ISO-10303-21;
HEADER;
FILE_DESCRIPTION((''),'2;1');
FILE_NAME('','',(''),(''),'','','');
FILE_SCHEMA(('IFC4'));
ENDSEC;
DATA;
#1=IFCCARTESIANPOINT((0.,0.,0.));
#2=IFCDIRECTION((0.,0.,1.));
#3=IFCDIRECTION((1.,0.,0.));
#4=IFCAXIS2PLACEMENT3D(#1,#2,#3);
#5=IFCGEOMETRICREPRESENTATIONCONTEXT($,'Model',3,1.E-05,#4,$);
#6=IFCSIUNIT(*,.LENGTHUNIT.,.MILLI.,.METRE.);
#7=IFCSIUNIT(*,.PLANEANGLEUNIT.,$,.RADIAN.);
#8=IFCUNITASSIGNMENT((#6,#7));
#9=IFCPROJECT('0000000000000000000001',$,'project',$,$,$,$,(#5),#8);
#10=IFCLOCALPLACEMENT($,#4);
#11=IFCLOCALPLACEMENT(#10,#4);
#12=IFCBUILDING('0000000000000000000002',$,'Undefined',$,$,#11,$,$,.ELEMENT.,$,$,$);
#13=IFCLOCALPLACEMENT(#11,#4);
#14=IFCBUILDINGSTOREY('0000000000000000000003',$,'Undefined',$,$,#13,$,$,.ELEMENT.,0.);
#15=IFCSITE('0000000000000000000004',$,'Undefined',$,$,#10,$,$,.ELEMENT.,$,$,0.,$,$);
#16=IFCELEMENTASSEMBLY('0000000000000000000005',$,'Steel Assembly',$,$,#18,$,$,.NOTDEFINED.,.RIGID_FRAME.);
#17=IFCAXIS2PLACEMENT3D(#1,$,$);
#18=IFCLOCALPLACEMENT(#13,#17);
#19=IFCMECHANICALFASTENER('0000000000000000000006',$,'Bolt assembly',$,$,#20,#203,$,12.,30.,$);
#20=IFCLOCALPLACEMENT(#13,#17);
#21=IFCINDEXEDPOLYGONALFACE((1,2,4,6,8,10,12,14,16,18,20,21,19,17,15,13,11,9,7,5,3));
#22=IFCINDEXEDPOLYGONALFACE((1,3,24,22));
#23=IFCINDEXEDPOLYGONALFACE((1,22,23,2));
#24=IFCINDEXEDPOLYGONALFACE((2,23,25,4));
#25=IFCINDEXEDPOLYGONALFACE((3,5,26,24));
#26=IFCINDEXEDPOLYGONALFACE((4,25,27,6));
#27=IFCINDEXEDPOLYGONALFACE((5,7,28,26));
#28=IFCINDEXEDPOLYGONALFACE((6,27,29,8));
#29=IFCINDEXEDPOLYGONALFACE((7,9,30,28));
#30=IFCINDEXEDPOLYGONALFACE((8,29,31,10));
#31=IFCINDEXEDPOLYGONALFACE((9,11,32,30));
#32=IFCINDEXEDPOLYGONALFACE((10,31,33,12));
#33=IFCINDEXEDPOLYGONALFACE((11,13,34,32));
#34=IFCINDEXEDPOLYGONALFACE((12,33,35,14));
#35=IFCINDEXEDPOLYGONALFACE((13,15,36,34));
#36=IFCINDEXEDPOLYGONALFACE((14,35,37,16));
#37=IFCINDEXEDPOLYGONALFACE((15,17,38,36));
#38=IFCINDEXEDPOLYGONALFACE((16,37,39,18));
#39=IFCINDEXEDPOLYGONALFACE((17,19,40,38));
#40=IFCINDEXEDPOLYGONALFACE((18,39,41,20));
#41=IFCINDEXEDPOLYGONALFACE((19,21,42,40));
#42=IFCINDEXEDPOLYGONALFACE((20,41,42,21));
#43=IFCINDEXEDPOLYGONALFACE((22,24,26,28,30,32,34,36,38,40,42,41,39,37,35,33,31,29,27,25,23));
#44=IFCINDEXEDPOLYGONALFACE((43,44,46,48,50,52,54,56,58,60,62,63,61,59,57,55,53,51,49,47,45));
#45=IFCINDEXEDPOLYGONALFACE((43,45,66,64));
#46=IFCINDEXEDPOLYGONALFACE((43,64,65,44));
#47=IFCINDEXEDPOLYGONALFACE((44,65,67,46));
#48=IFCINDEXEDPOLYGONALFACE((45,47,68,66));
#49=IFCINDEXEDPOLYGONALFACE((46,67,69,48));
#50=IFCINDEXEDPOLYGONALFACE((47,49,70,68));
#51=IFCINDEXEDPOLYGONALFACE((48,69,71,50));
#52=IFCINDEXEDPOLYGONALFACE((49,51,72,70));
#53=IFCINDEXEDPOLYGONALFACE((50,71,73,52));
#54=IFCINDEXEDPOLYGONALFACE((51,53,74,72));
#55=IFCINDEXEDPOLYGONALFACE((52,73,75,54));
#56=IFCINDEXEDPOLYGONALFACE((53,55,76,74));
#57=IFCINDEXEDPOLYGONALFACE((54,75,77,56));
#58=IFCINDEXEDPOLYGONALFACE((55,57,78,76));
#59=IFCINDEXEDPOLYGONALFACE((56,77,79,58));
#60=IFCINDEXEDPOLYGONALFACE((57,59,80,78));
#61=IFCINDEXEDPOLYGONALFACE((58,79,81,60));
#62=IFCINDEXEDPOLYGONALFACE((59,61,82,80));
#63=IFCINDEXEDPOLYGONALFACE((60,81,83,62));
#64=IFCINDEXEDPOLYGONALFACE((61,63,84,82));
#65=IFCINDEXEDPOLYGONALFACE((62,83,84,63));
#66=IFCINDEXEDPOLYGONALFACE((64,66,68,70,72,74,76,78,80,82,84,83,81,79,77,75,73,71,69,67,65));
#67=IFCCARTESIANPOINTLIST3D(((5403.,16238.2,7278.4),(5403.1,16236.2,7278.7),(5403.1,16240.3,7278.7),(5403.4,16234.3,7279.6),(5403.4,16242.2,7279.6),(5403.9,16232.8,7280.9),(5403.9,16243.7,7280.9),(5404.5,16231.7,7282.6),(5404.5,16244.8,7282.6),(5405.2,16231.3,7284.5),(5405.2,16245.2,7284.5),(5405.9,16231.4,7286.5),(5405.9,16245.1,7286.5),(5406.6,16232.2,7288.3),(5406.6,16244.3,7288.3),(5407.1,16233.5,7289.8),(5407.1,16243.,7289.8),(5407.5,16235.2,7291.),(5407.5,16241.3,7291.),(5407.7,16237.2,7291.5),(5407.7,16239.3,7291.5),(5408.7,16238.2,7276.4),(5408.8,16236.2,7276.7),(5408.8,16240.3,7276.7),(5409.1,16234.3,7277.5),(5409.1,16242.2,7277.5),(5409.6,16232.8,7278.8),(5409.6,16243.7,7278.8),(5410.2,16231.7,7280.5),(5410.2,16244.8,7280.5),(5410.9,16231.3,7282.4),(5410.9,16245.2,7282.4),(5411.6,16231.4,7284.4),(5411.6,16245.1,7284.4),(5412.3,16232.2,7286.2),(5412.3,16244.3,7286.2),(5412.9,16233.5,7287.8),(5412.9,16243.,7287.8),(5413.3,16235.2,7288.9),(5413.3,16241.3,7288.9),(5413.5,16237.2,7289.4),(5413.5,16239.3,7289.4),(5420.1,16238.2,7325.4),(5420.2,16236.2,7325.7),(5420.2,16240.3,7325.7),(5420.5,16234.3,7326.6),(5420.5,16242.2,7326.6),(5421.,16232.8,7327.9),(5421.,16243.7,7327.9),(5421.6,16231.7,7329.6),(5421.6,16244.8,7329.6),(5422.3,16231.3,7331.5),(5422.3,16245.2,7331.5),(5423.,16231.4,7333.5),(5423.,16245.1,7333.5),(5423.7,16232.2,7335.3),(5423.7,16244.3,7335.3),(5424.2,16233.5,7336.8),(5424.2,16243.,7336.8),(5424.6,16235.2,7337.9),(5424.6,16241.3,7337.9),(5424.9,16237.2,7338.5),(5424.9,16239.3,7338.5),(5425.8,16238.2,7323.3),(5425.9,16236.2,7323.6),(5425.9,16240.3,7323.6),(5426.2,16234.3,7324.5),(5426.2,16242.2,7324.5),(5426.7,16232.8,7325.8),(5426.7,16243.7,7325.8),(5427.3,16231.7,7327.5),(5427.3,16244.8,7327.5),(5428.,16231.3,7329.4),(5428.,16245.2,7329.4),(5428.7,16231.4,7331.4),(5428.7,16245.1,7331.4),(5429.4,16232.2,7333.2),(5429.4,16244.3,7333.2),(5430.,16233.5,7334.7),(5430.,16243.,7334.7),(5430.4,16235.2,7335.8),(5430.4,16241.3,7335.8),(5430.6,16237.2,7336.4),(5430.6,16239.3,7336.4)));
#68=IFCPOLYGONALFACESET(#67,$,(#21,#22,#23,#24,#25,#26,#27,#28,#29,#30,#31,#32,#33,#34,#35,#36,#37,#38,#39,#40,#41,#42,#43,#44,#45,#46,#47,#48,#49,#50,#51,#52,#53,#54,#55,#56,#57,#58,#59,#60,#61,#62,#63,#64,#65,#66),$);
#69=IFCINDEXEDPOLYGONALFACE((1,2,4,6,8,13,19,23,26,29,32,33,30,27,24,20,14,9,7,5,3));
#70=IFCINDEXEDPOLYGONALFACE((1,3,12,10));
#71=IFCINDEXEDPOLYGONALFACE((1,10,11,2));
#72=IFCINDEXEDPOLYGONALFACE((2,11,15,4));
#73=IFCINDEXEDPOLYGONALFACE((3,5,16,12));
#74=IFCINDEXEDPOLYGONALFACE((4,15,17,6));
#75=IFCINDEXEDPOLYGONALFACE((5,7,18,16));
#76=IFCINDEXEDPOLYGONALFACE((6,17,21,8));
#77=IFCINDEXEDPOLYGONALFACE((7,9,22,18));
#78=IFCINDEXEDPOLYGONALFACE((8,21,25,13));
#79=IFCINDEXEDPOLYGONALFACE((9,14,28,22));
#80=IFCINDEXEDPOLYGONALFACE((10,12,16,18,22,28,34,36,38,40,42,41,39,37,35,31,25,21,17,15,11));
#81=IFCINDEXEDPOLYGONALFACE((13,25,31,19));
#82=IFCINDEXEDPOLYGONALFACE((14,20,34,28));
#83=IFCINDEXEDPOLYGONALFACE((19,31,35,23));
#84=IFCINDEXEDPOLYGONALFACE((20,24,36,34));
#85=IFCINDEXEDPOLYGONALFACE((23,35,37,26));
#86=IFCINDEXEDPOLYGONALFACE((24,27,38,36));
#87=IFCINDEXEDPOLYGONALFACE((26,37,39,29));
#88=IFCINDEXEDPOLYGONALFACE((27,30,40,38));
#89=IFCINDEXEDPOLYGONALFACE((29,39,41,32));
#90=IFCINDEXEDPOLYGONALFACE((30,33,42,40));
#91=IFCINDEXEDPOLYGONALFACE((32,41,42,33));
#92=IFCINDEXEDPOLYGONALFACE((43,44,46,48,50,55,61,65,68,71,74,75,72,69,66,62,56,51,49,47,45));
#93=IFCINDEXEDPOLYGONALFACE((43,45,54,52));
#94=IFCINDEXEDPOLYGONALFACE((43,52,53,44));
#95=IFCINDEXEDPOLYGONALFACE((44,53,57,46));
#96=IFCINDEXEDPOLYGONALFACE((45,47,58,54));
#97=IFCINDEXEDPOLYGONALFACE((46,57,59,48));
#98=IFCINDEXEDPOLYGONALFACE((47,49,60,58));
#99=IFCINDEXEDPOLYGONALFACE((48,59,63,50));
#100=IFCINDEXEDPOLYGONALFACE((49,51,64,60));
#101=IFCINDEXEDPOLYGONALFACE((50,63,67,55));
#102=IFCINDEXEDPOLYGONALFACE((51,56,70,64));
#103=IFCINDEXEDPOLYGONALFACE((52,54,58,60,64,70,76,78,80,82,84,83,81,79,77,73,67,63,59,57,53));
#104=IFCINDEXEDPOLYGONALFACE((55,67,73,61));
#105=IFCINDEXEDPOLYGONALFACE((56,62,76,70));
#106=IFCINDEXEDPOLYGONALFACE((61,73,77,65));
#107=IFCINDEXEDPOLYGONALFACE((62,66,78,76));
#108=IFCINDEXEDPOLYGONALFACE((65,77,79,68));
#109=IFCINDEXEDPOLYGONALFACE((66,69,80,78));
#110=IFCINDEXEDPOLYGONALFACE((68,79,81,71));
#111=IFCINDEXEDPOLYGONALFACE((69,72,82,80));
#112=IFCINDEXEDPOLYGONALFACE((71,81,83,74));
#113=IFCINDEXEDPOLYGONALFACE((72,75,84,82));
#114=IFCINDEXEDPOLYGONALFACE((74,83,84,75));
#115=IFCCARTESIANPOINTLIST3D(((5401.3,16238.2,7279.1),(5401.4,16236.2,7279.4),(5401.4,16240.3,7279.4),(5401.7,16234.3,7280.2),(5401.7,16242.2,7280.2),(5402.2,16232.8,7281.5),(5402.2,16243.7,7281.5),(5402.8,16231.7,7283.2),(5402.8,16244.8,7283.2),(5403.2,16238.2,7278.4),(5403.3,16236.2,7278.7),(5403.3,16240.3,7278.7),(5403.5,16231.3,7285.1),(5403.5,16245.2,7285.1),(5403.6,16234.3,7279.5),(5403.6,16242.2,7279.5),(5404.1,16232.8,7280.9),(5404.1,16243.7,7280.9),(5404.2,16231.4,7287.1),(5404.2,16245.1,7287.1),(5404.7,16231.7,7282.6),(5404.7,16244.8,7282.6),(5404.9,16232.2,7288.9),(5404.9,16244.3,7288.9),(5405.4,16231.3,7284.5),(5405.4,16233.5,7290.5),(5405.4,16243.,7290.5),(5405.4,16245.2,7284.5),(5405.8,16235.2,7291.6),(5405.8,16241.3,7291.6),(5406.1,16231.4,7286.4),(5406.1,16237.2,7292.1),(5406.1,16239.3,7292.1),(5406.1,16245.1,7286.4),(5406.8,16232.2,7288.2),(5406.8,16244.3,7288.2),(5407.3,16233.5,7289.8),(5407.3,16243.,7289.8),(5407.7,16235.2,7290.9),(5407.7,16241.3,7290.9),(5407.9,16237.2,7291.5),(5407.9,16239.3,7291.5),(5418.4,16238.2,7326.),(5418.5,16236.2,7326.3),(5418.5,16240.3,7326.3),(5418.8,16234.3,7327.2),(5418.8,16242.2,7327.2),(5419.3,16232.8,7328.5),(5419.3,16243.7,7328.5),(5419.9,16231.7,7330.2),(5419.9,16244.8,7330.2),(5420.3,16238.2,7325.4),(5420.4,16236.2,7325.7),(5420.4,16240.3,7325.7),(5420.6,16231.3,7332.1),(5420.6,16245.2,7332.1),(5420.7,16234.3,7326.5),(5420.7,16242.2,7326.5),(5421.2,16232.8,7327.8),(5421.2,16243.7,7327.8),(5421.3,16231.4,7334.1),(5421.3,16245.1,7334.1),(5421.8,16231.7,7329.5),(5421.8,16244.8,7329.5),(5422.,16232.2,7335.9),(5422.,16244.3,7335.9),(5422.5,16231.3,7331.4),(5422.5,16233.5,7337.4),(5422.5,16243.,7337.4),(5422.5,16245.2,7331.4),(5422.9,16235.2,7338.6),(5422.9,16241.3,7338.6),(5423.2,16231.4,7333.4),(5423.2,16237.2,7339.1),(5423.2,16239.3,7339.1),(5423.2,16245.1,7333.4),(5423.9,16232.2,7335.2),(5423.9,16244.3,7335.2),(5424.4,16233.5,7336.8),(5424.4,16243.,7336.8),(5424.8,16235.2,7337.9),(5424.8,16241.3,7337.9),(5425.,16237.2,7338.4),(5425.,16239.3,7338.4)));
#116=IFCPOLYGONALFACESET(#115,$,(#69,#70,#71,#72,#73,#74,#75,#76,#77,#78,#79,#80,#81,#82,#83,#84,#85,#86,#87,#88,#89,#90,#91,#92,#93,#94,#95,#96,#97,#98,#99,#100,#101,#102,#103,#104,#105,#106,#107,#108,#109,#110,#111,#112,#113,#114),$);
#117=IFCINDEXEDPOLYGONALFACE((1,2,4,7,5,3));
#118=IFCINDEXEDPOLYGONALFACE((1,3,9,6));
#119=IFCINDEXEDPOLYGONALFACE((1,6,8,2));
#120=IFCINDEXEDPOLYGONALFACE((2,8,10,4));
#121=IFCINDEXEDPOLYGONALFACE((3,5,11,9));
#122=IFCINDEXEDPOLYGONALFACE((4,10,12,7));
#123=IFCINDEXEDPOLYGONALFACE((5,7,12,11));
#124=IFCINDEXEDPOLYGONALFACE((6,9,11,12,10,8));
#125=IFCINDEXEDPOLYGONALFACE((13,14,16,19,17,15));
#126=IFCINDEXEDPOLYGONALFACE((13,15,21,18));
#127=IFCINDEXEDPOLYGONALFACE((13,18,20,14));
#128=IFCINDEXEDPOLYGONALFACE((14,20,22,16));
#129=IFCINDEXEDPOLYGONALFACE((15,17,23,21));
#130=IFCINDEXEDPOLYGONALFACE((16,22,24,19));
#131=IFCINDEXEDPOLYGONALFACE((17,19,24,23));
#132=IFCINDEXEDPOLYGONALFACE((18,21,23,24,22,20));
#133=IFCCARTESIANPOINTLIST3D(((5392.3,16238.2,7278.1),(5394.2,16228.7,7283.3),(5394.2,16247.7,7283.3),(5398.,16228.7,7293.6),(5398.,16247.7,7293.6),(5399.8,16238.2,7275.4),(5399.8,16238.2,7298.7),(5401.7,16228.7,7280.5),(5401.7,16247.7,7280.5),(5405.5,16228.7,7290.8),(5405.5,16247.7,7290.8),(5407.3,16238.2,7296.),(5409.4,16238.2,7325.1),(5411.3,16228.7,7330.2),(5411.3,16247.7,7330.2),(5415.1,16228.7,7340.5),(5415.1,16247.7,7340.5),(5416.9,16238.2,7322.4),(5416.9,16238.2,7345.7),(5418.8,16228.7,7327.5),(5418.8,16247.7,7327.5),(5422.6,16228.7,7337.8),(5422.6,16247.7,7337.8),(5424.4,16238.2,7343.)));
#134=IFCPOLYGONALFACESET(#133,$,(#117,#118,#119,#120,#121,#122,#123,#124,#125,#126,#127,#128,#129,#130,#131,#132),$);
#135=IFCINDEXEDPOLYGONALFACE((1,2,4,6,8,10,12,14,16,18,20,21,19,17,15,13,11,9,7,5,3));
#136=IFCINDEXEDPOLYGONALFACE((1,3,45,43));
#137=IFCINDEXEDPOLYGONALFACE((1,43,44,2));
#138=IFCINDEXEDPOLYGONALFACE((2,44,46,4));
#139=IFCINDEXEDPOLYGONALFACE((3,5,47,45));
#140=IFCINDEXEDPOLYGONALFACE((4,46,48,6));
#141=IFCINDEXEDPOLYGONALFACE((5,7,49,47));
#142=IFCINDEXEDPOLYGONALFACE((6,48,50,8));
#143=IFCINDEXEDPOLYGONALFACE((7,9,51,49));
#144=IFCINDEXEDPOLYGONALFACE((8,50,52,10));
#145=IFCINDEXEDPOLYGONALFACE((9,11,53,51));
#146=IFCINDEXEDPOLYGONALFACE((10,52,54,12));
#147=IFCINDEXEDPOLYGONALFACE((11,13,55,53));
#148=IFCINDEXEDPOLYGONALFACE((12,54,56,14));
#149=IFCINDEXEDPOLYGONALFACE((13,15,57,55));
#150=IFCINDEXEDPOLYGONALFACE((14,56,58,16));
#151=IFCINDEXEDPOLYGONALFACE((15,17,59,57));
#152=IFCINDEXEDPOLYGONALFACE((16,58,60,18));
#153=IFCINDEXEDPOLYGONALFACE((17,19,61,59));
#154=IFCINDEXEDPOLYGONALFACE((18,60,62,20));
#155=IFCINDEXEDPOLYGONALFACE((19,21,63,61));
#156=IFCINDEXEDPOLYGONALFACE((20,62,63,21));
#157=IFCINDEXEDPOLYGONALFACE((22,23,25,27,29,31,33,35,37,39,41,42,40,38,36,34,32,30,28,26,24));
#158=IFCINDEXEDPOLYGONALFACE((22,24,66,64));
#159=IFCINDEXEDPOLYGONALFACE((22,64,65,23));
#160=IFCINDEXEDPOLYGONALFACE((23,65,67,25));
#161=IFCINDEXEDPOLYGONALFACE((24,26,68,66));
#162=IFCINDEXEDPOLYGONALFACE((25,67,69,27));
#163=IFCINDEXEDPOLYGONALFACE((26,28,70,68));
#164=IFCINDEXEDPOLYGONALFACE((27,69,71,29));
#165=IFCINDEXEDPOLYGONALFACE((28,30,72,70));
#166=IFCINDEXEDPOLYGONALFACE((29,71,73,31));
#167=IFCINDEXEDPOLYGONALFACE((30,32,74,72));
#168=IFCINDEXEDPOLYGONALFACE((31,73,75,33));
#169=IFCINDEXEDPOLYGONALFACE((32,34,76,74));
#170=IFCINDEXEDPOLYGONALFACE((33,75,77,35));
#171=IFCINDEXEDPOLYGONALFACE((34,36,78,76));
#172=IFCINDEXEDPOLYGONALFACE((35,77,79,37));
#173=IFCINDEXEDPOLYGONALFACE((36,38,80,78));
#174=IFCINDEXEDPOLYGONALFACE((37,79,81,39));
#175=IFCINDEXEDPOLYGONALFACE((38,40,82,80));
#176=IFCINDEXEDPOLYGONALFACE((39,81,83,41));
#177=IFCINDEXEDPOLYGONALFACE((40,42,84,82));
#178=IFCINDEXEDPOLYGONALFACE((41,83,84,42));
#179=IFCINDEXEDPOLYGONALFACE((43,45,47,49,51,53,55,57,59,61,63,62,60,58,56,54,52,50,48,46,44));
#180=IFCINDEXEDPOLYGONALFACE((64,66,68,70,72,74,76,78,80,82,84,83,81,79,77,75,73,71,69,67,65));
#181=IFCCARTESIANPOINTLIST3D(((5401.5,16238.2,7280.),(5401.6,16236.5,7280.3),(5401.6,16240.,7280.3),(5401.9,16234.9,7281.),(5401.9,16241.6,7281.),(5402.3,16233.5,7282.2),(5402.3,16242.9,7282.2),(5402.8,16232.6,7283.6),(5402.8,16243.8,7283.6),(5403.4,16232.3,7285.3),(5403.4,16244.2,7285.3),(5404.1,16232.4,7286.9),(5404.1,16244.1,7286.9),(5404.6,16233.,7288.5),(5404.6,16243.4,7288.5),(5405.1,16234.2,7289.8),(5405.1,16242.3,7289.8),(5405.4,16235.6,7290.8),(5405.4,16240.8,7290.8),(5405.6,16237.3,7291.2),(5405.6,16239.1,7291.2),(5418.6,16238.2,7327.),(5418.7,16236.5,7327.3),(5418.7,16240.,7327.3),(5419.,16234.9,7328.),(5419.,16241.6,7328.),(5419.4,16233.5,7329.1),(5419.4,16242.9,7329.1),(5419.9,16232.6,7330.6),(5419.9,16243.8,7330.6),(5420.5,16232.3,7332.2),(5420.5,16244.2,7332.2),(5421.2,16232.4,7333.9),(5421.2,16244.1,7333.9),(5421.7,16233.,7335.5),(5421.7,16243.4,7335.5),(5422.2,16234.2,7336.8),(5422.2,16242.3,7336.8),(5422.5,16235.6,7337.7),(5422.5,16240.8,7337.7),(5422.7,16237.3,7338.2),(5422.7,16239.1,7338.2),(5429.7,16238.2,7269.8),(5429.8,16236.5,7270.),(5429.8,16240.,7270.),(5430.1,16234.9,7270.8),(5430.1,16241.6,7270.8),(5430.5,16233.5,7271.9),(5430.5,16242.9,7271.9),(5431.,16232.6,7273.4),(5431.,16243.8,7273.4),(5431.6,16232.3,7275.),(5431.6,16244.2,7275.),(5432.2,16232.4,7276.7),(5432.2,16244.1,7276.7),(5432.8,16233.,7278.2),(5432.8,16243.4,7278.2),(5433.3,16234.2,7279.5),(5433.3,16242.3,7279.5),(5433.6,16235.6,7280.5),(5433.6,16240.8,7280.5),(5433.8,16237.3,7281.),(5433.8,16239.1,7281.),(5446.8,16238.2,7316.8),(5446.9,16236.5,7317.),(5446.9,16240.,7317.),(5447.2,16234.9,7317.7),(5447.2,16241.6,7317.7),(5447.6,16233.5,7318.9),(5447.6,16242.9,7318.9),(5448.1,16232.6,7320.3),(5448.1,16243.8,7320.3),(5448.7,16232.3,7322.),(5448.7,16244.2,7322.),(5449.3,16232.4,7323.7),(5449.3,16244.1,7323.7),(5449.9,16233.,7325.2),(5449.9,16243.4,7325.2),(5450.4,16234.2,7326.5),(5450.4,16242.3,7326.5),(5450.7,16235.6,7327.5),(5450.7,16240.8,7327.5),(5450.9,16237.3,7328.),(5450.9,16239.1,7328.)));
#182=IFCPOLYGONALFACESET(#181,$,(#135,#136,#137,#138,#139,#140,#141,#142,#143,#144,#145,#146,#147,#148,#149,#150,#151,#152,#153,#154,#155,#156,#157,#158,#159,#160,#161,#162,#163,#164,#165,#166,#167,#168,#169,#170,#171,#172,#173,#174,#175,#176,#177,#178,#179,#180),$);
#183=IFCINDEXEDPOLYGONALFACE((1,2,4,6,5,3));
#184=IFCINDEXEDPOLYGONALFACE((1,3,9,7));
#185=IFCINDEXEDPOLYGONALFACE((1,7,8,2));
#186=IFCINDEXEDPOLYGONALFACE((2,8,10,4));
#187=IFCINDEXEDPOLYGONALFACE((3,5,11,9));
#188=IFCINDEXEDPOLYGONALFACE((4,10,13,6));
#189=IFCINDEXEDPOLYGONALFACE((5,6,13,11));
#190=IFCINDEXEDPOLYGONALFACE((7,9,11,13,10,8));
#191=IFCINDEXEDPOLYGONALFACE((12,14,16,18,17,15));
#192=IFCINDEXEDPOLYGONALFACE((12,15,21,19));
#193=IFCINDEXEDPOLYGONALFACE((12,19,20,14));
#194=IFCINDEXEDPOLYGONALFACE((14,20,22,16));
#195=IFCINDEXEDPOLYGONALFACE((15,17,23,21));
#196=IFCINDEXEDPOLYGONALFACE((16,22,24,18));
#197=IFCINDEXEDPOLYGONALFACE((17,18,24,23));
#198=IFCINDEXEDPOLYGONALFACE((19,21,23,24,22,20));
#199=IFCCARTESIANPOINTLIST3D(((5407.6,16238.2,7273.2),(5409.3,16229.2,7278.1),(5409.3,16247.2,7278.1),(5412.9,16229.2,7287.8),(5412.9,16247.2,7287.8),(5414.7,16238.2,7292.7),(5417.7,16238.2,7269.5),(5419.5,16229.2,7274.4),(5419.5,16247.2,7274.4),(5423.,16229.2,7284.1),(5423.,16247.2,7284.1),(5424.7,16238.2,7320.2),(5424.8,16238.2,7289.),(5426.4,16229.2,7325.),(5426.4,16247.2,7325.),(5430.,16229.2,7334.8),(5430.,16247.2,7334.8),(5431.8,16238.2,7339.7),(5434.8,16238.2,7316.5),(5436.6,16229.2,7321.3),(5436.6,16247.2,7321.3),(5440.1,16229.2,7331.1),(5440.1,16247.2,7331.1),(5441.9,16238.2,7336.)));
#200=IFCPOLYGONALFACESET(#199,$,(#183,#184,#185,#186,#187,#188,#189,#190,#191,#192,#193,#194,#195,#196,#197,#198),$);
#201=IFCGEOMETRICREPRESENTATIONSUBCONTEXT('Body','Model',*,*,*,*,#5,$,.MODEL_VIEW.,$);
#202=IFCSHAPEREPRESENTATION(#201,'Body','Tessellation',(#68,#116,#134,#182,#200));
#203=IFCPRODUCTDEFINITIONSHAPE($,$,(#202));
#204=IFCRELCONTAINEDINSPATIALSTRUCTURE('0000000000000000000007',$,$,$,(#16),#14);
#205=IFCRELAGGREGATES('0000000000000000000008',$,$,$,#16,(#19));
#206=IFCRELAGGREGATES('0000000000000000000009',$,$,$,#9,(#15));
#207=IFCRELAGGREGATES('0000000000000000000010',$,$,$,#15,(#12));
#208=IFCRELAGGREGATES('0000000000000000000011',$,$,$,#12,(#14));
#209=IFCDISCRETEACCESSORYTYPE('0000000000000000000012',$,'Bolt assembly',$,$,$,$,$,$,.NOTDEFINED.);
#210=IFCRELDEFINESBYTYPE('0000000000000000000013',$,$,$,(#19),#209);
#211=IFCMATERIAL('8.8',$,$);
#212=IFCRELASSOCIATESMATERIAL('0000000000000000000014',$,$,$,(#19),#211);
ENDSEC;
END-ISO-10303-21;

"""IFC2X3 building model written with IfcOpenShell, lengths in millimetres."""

from ifc_helpers import new_model, si_unit, frame, origin_with_axes, origin_2d_with_axis, place, context, subcontext, project, spatial, polyline, circle, outline, extrude, source, transform, mapped, material, type_object, element, aggregate, save


model = new_model("IFC2X3")

# Units and contexts
model_context = context("Model", 3, precision=1e-05, world=origin_with_axes())
body_context = subcontext(model_context, "Body", "Model", "MODEL_VIEW")
ifc_project = project(units=[si_unit("LENGTHUNIT", "METRE", prefix="MILLI"), si_unit("PLANEANGLEUNIT", "RADIAN")], contexts=[model_context])

# Site, building, storey
site_placement = place(None, origin_with_axes())
site = spatial("IfcSite", under=ifc_project, at=site_placement, Name="Undefined", CompositionType="ELEMENT", RefElevation=0.0)
building_placement = place(site_placement, origin_with_axes())
building = spatial("IfcBuilding", under=site, at=building_placement, Name="Undefined", CompositionType="ELEMENT")
storey_placement = place(building_placement, origin_with_axes())
storey = spatial("IfcBuildingStorey", under=building, at=storey_placement, Name="Undefined", CompositionType="ELEMENT", Elevation=0.0)

# Shared definitions
ifc_material_1 = material(Name="8.8")
discrete_accessory_type_1 = type_object("IfcDiscreteAccessoryType", Name="Bolt assembly")

# Element assembly, mechanical fastener
shared_shape_1 = source(origin_with_axes(), body_context, "Body", "SweptSolid", [
    extrude(circle(Radius=7.0, at=origin_2d_with_axis()), frame((0.0, -6.1, 0.0), z_axis=(0.0, 1.0, 0.0), x_axis=(1.0, 0.0, 0.0)), (0.0, 0.0, 1.0), 6.1),
    extrude(circle(Radius=7.0, at=origin_2d_with_axis()), frame((0.0, -7.9, 0.0), z_axis=(0.0, 1.0, 0.0), x_axis=(1.0, 0.0, 0.0)), (0.0, 0.0, 1.0), 2.0),
    extrude(outline(polyline([(11.0, 0.0), (5.5, 9.5), (-5.5, 9.5), (-11.0, 0.0), (-5.5, -9.5), (5.5, -9.5), (11.0, 0.0)])), frame((0.0, -16.0, 0.0), z_axis=(0.0, 1.0, 0.0), x_axis=(1.0, 0.0, 0.0)), (0.0, 0.0, 1.0), 8.0),
    extrude(circle(Radius=6.0, at=origin_2d_with_axis()), frame((0.0, -8.0, 0.0), z_axis=(0.0, 1.0, 0.0), x_axis=(1.0, 0.0, 0.0)), (0.0, 0.0, 1.0), 30.0),
    extrude(outline(polyline([(10.4, 0.0), (5.2, 9.0), (-5.2, 9.0), (-10.4, 0.0), (-5.2, -9.0), (5.2, -9.0), (10.4, 0.0)])), frame((0.0, 0.0, 0.0), z_axis=(0.0, 1.0, 0.0), x_axis=(1.0, 0.0, 0.0)), (0.0, 0.0, 1.0), 10.8),
])
assembly_1_placement = place(storey_placement, origin_with_axes())
assembly_1 = element("IfcElementAssembly", 1, at=assembly_1_placement, inside=storey, Name="Steel Assembly", AssemblyPlace="NOTDEFINED", PredefinedType="RIGID_FRAME")
mechanical_fastener_1_placement = place(assembly_1_placement, frame((5428.2, 16238.2, 7329.9), z_axis=(0.0, -1.0, 0.0), x_axis=(-0.34202, 0.0, -0.939693)))
mechanical_fastener_1 = element("IfcMechanicalFastener", 2, at=mechanical_fastener_1_placement, type_object=discrete_accessory_type_1, material=ifc_material_1, Name="Bolt assembly", NominalDiameter=12.0, NominalLength=30.0, context=body_context, shape_type="MappedRepresentation", body=[
    mapped(shared_shape_1, transform((0.0, 0.0, 0.0))),
    mapped(shared_shape_1, transform((50.0, 0.0, 0.0))),
])

aggregate(assembly_1, [mechanical_fastener_1])

save(model, "model.ifc")
